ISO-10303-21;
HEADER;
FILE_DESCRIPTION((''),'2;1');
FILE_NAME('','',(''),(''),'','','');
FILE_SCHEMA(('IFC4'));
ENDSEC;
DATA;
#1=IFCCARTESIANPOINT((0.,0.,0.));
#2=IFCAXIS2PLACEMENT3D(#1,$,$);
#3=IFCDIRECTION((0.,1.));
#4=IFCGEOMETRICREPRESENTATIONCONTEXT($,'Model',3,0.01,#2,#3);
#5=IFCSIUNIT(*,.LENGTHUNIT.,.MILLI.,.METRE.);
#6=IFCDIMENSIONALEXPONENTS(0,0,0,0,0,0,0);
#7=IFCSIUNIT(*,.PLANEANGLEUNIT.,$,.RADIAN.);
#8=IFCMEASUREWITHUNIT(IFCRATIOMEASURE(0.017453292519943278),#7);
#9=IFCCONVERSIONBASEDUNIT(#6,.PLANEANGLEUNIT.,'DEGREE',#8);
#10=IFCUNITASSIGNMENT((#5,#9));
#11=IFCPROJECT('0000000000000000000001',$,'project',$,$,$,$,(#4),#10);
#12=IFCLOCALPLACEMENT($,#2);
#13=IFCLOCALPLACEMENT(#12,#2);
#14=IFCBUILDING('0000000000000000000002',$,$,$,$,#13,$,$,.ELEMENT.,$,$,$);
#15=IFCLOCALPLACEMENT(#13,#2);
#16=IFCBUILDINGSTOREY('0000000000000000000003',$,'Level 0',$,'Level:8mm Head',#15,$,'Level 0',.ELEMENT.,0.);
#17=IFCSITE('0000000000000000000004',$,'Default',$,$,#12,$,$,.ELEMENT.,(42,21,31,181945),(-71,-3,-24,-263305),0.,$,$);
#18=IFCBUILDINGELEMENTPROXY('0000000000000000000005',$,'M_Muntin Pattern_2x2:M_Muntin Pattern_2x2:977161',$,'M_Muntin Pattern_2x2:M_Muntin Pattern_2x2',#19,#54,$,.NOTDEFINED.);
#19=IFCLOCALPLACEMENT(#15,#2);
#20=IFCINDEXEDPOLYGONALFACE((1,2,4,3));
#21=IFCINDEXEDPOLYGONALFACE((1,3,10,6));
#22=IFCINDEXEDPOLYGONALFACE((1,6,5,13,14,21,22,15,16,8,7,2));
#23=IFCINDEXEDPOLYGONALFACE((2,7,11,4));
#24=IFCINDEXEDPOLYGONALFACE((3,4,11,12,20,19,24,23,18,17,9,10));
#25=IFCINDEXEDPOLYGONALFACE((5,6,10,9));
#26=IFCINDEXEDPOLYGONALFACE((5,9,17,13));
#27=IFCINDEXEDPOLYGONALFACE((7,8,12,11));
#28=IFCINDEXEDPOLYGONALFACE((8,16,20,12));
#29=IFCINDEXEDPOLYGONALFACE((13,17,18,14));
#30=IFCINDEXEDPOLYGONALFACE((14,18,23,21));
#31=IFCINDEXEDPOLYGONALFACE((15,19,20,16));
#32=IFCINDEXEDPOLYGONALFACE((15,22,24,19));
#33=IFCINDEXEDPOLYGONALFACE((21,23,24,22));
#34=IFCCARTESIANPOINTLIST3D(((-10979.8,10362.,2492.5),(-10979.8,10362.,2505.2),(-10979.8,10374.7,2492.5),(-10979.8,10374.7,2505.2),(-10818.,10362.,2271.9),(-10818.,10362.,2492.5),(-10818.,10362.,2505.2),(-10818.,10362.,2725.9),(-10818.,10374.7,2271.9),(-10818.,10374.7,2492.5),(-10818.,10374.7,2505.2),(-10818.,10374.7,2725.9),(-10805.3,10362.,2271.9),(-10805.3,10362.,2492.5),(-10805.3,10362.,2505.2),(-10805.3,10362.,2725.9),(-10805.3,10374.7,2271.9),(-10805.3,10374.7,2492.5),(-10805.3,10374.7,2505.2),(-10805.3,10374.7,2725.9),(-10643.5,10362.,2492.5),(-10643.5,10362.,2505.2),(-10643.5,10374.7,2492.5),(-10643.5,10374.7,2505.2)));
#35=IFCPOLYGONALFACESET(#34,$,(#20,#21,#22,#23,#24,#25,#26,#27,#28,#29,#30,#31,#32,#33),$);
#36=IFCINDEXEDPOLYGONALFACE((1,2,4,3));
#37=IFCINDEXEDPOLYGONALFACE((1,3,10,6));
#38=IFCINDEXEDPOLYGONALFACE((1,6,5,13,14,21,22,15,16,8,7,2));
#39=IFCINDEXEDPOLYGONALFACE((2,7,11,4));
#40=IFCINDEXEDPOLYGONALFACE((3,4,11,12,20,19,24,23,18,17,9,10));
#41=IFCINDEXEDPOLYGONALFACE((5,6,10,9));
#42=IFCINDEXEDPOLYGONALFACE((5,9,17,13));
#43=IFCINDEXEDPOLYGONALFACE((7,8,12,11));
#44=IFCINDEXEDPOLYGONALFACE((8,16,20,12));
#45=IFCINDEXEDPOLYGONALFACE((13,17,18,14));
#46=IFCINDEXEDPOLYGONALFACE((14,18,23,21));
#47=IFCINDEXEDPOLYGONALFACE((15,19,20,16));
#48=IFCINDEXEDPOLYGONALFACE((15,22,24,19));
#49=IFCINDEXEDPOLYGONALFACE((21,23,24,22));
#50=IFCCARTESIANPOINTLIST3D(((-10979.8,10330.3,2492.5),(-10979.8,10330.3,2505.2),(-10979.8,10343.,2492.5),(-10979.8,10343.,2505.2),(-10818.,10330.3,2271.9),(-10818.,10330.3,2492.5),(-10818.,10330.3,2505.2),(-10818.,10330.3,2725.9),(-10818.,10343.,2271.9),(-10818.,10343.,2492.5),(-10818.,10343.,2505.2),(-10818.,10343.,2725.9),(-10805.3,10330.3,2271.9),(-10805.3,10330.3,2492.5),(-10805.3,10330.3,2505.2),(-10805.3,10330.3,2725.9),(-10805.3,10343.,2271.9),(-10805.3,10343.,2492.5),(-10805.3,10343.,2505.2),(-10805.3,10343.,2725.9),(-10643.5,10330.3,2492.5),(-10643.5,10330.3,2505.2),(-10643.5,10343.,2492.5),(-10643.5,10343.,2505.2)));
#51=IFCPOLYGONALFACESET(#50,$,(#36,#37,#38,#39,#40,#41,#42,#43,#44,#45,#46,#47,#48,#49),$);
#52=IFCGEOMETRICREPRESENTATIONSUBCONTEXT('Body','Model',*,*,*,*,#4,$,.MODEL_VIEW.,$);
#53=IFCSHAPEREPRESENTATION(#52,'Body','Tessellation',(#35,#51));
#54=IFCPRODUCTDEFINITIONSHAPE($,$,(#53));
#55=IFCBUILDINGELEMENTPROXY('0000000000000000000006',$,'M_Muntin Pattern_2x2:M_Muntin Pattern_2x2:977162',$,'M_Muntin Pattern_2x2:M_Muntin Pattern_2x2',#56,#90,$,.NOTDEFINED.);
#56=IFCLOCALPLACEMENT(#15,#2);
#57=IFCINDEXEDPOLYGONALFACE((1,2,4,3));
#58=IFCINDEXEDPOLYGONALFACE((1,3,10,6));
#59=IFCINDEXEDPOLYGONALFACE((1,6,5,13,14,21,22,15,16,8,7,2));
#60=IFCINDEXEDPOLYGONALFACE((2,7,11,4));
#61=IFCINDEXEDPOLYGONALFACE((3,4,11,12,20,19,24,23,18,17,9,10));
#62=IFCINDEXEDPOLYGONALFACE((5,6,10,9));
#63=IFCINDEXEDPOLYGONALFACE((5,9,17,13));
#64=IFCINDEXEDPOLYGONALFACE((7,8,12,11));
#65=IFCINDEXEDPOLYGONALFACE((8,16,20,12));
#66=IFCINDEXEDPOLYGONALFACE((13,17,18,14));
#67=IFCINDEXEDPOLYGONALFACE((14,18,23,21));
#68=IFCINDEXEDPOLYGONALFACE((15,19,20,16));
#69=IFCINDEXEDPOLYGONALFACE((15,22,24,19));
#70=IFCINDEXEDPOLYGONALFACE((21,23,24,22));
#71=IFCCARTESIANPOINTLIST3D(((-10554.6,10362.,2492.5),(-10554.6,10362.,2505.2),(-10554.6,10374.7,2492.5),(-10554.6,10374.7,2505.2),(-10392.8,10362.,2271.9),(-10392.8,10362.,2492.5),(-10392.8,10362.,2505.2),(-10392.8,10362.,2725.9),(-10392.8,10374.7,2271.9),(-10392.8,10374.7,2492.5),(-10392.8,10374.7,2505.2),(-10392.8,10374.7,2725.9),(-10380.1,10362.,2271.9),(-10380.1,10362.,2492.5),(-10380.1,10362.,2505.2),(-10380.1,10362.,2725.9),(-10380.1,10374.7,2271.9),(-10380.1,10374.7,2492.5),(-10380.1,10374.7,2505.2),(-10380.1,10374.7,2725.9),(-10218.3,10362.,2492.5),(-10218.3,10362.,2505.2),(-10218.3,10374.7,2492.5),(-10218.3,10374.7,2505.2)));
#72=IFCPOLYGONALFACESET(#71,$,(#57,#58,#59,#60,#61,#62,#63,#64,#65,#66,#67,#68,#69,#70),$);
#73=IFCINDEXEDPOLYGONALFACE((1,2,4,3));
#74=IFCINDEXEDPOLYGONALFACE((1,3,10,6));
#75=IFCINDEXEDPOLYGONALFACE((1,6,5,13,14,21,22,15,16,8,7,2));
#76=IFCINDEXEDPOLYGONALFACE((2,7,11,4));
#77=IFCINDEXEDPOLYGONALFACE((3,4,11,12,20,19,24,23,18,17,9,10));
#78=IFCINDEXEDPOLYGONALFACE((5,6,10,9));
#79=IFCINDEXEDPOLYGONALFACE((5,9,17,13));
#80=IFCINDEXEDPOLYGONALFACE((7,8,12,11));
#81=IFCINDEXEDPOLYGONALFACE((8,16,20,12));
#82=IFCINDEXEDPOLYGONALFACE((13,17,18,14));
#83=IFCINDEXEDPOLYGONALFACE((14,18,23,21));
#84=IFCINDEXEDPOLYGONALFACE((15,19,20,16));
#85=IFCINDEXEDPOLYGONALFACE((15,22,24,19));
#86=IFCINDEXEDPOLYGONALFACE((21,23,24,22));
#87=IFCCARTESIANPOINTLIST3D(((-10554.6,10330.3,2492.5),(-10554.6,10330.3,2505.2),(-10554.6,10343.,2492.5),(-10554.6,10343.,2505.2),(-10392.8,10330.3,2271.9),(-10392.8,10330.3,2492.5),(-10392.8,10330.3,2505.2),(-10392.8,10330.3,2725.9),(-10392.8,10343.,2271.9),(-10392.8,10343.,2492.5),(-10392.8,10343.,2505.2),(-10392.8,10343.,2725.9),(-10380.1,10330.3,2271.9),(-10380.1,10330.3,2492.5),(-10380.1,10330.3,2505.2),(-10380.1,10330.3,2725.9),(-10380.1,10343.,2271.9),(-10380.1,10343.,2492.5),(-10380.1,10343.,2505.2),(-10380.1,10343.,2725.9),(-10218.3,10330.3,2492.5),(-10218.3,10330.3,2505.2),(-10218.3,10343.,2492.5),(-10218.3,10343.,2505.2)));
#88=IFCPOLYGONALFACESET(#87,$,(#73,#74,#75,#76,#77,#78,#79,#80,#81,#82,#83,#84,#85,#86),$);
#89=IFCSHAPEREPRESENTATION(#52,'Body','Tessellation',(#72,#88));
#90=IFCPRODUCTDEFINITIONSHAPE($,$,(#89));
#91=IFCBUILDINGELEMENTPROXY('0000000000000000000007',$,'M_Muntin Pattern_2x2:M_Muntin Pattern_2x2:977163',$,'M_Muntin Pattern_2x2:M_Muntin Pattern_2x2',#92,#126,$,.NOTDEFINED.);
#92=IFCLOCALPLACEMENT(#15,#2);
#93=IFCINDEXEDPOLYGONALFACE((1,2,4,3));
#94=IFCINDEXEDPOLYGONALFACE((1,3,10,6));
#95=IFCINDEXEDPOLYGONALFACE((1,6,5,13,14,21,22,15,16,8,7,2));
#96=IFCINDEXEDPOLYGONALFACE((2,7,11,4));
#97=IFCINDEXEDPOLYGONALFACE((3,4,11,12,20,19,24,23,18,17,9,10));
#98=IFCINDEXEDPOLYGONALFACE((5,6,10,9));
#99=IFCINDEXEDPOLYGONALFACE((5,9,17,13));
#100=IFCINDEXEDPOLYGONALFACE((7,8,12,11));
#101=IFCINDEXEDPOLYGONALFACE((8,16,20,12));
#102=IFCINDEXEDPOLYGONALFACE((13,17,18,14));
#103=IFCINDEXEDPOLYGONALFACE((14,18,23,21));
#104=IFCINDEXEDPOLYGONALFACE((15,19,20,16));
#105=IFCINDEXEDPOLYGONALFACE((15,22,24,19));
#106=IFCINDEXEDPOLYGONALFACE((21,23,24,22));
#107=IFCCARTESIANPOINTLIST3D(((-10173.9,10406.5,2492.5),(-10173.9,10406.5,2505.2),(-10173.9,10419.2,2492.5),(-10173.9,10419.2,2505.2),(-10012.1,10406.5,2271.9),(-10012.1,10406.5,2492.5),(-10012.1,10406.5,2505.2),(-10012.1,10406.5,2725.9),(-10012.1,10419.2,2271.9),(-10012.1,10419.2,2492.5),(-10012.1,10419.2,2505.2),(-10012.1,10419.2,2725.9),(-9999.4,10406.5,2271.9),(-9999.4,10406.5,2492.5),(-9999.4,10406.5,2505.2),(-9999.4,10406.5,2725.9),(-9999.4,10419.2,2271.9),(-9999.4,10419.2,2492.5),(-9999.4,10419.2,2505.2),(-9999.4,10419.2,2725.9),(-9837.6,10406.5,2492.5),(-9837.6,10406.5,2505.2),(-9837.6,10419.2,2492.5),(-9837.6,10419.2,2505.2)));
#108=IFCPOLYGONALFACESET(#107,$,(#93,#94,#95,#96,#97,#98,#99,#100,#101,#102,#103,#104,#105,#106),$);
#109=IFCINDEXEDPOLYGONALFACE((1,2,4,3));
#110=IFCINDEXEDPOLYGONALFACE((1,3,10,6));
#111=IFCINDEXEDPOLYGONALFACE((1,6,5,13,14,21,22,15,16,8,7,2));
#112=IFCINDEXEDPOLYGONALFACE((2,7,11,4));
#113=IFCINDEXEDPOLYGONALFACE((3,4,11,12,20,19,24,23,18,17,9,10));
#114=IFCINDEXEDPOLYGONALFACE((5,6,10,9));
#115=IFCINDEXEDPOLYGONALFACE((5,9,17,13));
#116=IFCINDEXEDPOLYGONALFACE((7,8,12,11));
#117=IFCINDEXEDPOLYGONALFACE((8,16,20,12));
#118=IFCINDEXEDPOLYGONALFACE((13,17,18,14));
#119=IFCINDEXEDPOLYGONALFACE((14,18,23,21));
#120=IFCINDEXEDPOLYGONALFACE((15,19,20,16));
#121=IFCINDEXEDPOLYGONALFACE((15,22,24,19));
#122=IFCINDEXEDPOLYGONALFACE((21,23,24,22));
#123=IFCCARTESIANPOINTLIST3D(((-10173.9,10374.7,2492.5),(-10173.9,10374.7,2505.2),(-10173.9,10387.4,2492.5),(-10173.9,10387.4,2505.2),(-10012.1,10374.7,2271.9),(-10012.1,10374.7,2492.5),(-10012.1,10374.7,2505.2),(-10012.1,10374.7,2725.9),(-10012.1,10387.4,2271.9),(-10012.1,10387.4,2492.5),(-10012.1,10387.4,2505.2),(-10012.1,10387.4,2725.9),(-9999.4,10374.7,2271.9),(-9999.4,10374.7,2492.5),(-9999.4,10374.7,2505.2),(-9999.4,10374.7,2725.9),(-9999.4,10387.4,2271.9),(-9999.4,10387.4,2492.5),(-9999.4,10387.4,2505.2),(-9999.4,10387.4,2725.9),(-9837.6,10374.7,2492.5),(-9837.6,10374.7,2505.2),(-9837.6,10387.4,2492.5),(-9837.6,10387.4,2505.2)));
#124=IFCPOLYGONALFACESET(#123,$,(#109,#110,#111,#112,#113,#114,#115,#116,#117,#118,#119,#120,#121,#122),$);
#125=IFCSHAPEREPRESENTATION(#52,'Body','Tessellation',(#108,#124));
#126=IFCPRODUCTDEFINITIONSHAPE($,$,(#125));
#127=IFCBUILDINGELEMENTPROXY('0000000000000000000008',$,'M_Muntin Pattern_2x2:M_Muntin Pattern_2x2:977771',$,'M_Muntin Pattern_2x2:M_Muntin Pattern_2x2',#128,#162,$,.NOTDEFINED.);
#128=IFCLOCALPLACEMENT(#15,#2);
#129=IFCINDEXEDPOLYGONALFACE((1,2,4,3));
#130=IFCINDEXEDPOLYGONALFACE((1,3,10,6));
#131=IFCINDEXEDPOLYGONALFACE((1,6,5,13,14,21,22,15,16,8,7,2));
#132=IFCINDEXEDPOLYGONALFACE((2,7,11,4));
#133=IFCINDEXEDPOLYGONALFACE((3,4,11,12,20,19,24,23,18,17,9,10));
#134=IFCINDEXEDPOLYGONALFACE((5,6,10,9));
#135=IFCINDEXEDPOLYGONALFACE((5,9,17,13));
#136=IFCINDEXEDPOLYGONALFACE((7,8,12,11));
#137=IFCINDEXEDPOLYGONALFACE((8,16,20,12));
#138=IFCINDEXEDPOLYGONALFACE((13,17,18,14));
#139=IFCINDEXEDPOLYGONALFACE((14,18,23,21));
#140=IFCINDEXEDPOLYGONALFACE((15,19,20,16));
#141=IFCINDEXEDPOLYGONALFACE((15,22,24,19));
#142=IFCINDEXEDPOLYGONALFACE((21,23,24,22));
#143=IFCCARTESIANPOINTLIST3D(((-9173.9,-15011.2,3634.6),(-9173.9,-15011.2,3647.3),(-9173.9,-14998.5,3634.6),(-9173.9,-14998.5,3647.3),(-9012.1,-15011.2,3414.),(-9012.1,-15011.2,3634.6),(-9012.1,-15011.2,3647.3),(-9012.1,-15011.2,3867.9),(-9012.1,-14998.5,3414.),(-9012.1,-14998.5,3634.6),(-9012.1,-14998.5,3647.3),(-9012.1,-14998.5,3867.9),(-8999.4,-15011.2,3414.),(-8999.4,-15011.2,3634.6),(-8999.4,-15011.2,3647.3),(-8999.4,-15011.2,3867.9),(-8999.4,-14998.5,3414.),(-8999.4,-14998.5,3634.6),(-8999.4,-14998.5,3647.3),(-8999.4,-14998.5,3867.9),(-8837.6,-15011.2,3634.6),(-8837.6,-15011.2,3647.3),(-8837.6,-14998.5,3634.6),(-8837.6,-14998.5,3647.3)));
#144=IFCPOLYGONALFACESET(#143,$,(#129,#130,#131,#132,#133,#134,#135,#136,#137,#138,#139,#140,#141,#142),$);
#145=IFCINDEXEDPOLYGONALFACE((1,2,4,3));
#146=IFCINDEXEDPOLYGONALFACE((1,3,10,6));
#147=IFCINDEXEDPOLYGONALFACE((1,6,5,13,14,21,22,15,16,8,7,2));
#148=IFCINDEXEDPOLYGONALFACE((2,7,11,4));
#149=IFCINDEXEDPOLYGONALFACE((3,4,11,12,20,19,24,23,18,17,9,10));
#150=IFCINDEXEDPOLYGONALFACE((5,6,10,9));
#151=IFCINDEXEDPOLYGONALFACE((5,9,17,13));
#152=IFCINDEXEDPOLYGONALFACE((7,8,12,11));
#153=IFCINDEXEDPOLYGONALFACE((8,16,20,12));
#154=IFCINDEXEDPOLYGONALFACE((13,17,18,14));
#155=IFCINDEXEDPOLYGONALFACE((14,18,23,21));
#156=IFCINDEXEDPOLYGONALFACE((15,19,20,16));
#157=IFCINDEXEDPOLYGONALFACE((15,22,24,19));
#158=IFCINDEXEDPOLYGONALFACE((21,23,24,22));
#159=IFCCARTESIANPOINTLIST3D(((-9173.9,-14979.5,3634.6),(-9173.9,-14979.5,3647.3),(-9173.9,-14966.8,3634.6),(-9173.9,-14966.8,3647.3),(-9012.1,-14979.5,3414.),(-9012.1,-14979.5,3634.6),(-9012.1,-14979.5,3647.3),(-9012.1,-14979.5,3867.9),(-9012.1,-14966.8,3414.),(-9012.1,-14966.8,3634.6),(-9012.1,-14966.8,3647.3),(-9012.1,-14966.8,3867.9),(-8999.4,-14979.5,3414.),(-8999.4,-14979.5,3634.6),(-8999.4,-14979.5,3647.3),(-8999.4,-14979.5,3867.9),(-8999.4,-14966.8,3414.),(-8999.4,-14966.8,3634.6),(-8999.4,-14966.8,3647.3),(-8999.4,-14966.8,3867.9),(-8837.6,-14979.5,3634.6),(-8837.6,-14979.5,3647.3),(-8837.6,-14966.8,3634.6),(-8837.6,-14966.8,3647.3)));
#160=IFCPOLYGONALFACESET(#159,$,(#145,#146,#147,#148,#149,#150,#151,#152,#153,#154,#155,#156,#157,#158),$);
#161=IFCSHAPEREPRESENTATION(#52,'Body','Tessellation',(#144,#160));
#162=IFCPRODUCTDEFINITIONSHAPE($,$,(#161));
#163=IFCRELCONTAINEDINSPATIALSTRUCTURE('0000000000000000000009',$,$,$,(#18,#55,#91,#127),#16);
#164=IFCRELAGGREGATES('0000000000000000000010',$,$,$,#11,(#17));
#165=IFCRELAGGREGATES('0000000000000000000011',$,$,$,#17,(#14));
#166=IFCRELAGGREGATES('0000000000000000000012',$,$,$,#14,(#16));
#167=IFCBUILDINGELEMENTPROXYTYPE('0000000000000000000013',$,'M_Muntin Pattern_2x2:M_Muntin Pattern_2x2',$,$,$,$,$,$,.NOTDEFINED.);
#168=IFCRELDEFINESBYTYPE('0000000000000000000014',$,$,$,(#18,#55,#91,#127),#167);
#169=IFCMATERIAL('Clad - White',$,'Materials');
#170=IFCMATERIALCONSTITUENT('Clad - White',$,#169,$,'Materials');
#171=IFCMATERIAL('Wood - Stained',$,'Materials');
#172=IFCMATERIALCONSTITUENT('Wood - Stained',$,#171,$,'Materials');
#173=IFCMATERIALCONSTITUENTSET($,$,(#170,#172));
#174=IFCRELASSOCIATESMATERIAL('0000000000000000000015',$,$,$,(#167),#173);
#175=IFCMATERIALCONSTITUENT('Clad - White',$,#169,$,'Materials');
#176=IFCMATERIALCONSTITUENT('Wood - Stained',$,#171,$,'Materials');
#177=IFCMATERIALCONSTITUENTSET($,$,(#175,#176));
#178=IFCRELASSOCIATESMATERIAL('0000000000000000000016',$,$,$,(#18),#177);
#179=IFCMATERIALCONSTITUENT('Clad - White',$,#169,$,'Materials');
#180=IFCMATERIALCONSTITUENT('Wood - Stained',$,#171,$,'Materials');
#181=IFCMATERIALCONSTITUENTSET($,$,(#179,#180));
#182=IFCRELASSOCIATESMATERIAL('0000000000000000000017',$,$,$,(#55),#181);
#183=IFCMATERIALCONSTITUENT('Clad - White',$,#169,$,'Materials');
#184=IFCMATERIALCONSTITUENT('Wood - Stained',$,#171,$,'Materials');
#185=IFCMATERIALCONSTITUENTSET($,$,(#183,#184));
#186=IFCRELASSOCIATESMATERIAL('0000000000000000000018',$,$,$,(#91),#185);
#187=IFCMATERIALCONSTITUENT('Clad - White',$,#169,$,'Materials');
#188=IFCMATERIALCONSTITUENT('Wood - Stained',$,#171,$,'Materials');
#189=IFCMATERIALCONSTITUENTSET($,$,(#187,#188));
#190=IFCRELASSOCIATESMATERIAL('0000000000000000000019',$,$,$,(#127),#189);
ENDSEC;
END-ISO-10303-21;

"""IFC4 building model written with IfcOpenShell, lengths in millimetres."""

from ifc_helpers import new_model, entity, si_unit, converted_unit, direction, frame, origin, place, context, subcontext, project, spatial, indexed_curve, outline, extrude, source, transform, mapped, material, constituent, constituent_set, type_object, type_shapes, element, save


model = new_model("IFC4")

# Units and contexts
model_context = context("Model", 3, precision=0.01, world=origin(), true_north=direction((0.0, 1.0)))
body_context = subcontext(model_context, "Body", "Model", "MODEL_VIEW")
ifc_project = project(units=[si_unit("LENGTHUNIT", "METRE", prefix="MILLI"), converted_unit("PLANEANGLEUNIT", "DEGREE", entity("IfcRatioMeasure", 0.017453292519943278), si_unit("PLANEANGLEUNIT", "RADIAN"), dimensions=[0, 0, 0, 0, 0, 0, 0])], contexts=[model_context])

# Site, building, storey
site_placement = place(None, origin())
site = spatial("IfcSite", under=ifc_project, at=site_placement, Name="Default", CompositionType="ELEMENT", RefLatitude=(42, 21, 31, 181945), RefLongitude=(-71, -3, -24, -263305), RefElevation=0.0)
building_placement = place(site_placement, origin())
building = spatial("IfcBuilding", under=site, at=building_placement, CompositionType="ELEMENT")
storey_placement = place(building_placement, origin())
storey = spatial("IfcBuildingStorey", under=building, at=storey_placement, Name="Level 0", ObjectType="Level:8mm Head", LongName="Level 0", CompositionType="ELEMENT", Elevation=0.0)

# Building element proxies
ifc_material_1 = material(Name="Clad - White", Category="Materials")
ifc_material_2 = material(Name="Wood - Stained", Category="Materials")
ifc_constituent_1 = constituent(ifc_material_1, Name="Clad - White", Category="Materials")
ifc_constituent_2 = constituent(ifc_material_2, Name="Wood - Stained", Category="Materials")
ifc_constituent_set_1 = constituent_set(constituents=[ifc_constituent_1, ifc_constituent_2])
building_element_proxy_type_1 = type_object("IfcBuildingElementProxyType", Name="M_Muntin Pattern_2x2:M_Muntin Pattern_2x2", PredefinedType="NOTDEFINED", material=ifc_constituent_set_1)
shared_shape_1 = source(origin(), body_context, "Body", "SweptSolid", [
    extrude(outline(indexed_curve([(6.4, -6.4), (227.0, -6.4), (227.0, 6.3), (6.4, 6.3), (6.4, 168.2), (-6.3, 168.2), (-6.3, 6.3), (-227.0, 6.3), (-227.0, -6.4), (-6.3, -6.4), (-6.3, -168.1), (6.4, -168.1), (6.4, -6.4)], self_intersect=False)), frame((0.0, 9.5, 227.0), z_axis=(0.0, 1.0, 0.0), x_axis=(0.0, 0.0, 1.0)), (0.0, 0.0, 1.0), 12.7),
    extrude(outline(indexed_curve([(6.4, -6.4), (227.0, -6.4), (227.0, 6.3), (6.4, 6.3), (6.4, 168.2), (-6.3, 168.2), (-6.3, 6.3), (-227.0, 6.3), (-227.0, -6.4), (-6.3, -6.4), (-6.3, -168.1), (6.4, -168.1), (6.4, -6.4)], self_intersect=False)), frame((0.0, -22.2, 227.0), z_axis=(0.0, 1.0, 0.0), x_axis=(0.0, 0.0, 1.0)), (0.0, 0.0, 1.0), 12.7),
])
type_shapes(building_element_proxy_type_1, [shared_shape_1])
ifc_constituent_3 = constituent(ifc_material_1, Name="Clad - White", Category="Materials")
ifc_constituent_4 = constituent(ifc_material_2, Name="Wood - Stained", Category="Materials")
ifc_constituent_set_2 = constituent_set(constituents=[ifc_constituent_3, ifc_constituent_4])
proxy_1_placement = place(storey_placement, frame((-10811.7, 10352.5, 2271.9)))
element("IfcBuildingElementProxy", 1, at=proxy_1_placement, inside=storey, type_object=building_element_proxy_type_1, material=ifc_constituent_set_2, Name="M_Muntin Pattern_2x2:M_Muntin Pattern_2x2:977161", ObjectType="M_Muntin Pattern_2x2:M_Muntin Pattern_2x2", PredefinedType="NOTDEFINED", context=body_context, shape_type="MappedRepresentation", body=[
    mapped(shared_shape_1, transform((0.0, 0.0, 0.0), scale=1.0)),
])
ifc_constituent_5 = constituent(ifc_material_1, Name="Clad - White", Category="Materials")
ifc_constituent_6 = constituent(ifc_material_2, Name="Wood - Stained", Category="Materials")
ifc_constituent_set_3 = constituent_set(constituents=[ifc_constituent_5, ifc_constituent_6])
proxy_2_placement = place(storey_placement, frame((-10386.5, 10352.5, 2271.9)))
element("IfcBuildingElementProxy", 2, at=proxy_2_placement, inside=storey, type_object=building_element_proxy_type_1, material=ifc_constituent_set_3, Name="M_Muntin Pattern_2x2:M_Muntin Pattern_2x2:977162", ObjectType="M_Muntin Pattern_2x2:M_Muntin Pattern_2x2", PredefinedType="NOTDEFINED", context=body_context, shape_type="MappedRepresentation", body=[
    mapped(shared_shape_1, transform((0.0, 0.0, 0.0), scale=1.0)),
])
ifc_constituent_7 = constituent(ifc_material_1, Name="Clad - White", Category="Materials")
ifc_constituent_8 = constituent(ifc_material_2, Name="Wood - Stained", Category="Materials")
ifc_constituent_set_4 = constituent_set(constituents=[ifc_constituent_7, ifc_constituent_8])
proxy_3_placement = place(storey_placement, frame((-10005.7, 10396.9, 2271.9)))
element("IfcBuildingElementProxy", 3, at=proxy_3_placement, inside=storey, type_object=building_element_proxy_type_1, material=ifc_constituent_set_4, Name="M_Muntin Pattern_2x2:M_Muntin Pattern_2x2:977163", ObjectType="M_Muntin Pattern_2x2:M_Muntin Pattern_2x2", PredefinedType="NOTDEFINED", context=body_context, shape_type="MappedRepresentation", body=[
    mapped(shared_shape_1, transform((0.0, 0.0, 0.0), scale=1.0)),
])
ifc_constituent_9 = constituent(ifc_material_1, Name="Clad - White", Category="Materials")
ifc_constituent_10 = constituent(ifc_material_2, Name="Wood - Stained", Category="Materials")
ifc_constituent_set_5 = constituent_set(constituents=[ifc_constituent_9, ifc_constituent_10])
proxy_4_placement = place(storey_placement, frame((-9005.7, -14989.0, 3414.0), z_axis=(0.0, 0.0, 1.0), x_axis=(-1.0, 0.0, 0.0)))
element("IfcBuildingElementProxy", 4, at=proxy_4_placement, inside=storey, type_object=building_element_proxy_type_1, material=ifc_constituent_set_5, Name="M_Muntin Pattern_2x2:M_Muntin Pattern_2x2:977771", ObjectType="M_Muntin Pattern_2x2:M_Muntin Pattern_2x2", PredefinedType="NOTDEFINED", context=body_context, shape_type="MappedRepresentation", body=[
    mapped(shared_shape_1, transform((0.0, 0.0, 0.0), scale=1.0)),
])

save(model, "model.ifc")
